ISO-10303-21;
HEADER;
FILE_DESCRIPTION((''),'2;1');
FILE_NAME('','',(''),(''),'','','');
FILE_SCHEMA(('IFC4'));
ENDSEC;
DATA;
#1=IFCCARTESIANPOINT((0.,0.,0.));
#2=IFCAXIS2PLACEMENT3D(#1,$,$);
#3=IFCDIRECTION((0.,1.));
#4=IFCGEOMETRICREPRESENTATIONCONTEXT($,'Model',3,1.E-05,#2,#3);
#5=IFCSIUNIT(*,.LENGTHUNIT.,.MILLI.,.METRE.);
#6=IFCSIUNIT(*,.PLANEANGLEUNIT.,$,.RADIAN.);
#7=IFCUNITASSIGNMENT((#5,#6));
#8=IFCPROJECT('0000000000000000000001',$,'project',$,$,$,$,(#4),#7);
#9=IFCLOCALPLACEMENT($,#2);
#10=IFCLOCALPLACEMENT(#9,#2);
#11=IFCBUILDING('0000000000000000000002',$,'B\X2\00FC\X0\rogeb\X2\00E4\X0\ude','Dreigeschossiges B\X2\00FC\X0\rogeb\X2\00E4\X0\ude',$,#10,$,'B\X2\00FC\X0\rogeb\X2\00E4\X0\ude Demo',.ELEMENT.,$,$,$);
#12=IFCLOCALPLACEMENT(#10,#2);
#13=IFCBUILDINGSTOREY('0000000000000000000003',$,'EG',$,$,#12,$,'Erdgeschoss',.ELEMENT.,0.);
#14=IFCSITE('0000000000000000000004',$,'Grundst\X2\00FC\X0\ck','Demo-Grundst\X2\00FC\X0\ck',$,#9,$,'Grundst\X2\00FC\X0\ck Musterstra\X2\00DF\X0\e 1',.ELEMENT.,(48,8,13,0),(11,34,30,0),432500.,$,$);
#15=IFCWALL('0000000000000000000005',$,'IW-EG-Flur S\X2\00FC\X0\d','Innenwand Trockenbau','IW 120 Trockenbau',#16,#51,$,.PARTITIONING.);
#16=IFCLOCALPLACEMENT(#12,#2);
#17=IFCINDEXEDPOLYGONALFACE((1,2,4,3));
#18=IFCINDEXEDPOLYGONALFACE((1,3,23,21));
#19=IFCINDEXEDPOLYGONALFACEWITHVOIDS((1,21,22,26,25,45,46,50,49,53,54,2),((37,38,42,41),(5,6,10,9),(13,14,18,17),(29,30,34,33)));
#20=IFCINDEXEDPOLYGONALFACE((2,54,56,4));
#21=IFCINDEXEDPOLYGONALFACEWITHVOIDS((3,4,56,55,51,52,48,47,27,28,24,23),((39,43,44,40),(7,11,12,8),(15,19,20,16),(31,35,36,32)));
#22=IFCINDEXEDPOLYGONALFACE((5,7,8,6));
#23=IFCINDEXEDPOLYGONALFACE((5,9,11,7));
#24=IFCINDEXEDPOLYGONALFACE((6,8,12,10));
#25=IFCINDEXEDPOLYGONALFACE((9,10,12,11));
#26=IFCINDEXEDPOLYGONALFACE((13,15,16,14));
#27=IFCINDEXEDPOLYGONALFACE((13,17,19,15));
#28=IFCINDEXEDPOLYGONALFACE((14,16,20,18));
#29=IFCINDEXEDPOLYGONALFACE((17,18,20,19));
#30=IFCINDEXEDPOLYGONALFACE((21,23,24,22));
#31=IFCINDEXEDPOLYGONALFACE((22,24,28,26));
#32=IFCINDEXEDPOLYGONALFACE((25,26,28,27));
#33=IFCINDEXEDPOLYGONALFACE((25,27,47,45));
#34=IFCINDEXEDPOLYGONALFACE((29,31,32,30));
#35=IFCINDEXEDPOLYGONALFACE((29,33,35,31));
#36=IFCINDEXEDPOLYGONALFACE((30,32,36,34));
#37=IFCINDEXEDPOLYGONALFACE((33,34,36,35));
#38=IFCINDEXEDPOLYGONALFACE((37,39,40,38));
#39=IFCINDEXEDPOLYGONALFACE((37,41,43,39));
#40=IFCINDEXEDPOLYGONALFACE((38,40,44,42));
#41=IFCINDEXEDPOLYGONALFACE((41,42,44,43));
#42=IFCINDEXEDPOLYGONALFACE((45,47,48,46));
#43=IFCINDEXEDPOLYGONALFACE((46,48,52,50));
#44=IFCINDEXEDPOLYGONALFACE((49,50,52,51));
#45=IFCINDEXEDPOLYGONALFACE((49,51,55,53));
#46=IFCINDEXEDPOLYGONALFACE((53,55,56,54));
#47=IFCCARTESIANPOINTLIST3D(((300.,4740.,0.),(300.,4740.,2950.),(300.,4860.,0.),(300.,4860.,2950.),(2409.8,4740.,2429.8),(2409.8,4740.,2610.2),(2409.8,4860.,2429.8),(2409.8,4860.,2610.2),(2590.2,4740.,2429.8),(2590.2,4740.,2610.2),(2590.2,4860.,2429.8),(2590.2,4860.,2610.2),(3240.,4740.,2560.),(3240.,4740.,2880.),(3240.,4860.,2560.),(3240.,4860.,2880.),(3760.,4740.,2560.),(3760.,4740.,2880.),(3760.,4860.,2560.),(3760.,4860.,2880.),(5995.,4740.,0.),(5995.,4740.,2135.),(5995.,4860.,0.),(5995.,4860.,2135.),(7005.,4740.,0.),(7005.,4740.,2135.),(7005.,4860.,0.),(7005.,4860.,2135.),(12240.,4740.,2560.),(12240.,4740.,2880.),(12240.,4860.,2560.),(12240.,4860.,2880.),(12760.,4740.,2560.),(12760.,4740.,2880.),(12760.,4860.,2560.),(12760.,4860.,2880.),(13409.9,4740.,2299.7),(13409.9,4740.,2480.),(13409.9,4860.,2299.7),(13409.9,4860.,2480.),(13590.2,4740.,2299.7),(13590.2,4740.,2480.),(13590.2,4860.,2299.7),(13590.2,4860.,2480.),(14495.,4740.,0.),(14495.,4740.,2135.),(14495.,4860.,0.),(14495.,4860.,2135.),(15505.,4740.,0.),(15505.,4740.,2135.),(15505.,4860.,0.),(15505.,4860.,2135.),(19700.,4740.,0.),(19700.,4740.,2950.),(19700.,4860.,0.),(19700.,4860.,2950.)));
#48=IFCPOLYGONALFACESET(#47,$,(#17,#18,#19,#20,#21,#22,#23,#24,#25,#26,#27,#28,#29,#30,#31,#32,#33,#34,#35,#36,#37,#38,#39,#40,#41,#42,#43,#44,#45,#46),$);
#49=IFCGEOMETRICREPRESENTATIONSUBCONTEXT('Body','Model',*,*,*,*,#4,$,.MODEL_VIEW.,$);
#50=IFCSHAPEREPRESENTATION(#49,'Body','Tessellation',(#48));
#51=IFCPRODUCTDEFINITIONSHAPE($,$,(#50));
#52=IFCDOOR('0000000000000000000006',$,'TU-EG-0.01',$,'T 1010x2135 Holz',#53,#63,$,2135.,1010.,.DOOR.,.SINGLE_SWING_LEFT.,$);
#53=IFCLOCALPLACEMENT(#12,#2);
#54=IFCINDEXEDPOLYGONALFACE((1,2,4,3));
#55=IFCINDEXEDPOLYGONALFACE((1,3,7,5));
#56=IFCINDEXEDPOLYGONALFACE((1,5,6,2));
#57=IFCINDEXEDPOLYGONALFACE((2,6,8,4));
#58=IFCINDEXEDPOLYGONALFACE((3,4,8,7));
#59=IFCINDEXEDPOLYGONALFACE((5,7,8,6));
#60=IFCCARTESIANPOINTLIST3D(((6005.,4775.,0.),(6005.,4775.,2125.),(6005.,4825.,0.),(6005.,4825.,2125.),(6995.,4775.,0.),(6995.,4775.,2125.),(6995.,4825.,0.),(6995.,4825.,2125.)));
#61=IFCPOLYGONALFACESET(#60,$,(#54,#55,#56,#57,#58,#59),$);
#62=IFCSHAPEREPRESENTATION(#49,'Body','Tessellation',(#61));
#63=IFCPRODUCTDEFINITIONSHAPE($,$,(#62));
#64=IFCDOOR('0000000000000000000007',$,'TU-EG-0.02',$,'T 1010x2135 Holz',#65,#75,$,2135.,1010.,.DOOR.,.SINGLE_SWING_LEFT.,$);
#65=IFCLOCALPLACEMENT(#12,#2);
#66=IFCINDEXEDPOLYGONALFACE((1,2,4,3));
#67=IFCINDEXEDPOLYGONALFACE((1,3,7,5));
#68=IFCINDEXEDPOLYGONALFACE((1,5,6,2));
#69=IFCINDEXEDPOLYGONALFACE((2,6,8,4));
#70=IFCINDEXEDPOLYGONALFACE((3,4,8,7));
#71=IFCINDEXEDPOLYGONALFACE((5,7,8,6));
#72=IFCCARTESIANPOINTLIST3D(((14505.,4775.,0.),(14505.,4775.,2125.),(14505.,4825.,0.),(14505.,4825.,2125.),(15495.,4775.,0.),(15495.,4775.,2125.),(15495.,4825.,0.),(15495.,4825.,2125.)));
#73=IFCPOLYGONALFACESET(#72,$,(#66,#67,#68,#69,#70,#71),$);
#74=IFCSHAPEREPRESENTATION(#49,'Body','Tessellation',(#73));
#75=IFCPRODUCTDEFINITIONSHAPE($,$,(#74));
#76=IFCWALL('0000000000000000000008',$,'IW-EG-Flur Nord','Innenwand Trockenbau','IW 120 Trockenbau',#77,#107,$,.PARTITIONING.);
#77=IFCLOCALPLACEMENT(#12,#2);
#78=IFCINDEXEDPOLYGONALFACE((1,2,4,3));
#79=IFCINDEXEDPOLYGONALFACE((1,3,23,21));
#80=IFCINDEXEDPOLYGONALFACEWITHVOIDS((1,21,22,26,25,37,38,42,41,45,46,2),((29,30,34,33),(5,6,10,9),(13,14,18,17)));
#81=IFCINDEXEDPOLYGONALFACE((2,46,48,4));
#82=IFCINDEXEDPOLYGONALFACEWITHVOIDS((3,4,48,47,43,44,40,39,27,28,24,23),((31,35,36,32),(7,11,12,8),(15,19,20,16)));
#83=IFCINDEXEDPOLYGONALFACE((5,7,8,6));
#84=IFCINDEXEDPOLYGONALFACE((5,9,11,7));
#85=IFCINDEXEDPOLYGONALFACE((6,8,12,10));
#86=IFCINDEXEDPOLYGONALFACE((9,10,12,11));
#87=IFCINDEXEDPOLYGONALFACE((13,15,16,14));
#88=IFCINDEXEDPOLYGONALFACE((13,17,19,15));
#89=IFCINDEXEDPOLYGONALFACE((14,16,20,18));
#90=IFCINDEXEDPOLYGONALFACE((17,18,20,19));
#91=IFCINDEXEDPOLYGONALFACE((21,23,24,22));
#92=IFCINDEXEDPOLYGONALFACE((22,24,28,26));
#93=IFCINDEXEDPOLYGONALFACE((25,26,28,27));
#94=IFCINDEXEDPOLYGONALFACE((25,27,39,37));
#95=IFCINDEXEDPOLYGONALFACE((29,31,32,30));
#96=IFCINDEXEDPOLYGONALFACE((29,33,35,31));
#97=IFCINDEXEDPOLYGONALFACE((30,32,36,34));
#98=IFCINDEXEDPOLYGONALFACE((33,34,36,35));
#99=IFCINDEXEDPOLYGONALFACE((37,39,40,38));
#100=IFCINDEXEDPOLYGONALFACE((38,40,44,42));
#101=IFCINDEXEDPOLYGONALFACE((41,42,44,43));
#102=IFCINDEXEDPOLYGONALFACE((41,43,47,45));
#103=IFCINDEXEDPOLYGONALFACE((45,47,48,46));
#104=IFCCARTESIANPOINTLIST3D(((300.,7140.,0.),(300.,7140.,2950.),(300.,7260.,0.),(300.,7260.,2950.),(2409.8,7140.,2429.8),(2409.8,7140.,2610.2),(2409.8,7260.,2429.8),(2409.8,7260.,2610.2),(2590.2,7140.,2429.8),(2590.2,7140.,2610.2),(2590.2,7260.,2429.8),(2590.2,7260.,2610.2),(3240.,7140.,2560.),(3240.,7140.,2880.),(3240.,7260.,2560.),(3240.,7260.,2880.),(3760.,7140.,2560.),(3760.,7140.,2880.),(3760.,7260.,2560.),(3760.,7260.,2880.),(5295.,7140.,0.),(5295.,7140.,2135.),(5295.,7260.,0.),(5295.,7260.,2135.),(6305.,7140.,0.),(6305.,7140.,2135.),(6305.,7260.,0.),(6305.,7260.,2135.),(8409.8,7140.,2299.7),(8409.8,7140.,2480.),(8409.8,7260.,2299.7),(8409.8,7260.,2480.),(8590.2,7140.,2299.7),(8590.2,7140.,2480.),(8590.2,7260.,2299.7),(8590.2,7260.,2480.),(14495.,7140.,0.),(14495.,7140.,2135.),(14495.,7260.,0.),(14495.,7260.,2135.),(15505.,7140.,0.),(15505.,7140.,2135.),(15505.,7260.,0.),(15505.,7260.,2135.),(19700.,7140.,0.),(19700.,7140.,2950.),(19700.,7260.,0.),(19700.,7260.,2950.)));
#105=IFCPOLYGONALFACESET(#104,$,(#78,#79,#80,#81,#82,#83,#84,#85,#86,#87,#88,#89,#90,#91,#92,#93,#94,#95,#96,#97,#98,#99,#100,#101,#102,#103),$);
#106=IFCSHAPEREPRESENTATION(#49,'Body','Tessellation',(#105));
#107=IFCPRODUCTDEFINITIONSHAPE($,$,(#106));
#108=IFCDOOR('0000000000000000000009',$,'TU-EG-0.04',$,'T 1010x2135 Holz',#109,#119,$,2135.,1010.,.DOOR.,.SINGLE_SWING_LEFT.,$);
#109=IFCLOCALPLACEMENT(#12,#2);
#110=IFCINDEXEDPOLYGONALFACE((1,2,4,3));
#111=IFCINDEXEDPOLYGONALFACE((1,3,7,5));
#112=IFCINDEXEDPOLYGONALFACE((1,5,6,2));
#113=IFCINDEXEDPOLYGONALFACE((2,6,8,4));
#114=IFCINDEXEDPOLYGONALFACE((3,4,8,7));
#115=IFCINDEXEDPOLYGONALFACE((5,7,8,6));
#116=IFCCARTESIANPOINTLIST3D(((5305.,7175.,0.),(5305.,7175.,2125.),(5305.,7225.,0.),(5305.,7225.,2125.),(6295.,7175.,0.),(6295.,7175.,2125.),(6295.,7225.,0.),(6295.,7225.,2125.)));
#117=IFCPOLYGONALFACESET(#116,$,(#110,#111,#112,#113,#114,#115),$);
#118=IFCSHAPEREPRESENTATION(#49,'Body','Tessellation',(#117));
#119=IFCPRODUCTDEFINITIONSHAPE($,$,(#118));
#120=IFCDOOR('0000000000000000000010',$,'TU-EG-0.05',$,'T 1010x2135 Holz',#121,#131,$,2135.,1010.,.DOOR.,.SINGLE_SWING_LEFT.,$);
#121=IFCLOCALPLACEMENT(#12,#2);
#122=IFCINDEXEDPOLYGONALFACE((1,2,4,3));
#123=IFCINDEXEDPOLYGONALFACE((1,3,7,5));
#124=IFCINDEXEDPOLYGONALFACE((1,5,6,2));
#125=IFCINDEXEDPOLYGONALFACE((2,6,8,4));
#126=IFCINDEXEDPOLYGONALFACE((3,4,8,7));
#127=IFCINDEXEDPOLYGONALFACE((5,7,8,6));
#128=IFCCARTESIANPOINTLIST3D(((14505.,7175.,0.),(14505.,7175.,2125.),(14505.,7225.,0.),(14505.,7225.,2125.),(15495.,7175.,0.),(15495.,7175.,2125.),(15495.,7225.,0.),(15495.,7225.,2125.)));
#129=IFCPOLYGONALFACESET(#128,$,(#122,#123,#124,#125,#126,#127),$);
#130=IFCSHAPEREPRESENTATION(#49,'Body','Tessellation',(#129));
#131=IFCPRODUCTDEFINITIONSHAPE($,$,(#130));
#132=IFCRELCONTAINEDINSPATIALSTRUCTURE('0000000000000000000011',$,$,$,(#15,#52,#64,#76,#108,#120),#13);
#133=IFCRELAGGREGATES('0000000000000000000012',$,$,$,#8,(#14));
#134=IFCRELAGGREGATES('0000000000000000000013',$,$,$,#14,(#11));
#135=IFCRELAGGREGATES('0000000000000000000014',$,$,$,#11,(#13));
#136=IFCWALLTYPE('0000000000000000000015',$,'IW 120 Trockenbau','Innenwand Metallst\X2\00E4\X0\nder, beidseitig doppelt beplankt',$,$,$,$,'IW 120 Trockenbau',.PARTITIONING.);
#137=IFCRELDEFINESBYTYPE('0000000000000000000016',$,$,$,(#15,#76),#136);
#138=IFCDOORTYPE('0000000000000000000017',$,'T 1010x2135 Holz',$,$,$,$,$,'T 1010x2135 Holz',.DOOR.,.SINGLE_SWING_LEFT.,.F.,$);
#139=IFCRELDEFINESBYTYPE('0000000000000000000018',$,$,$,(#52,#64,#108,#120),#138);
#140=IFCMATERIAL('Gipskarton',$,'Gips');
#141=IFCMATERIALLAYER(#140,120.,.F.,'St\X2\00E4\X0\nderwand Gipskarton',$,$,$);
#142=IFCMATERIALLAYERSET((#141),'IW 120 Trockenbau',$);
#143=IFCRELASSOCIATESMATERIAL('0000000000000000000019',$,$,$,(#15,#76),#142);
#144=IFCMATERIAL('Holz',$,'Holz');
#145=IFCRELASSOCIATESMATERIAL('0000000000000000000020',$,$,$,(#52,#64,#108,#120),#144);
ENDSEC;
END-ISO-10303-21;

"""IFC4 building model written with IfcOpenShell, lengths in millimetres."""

from ifc_helpers import new_model, si_unit, direction, frame, frame_2d, origin, origin_2d, place, context, subcontext, project, spatial, rectangle, extrude, material, layer, layer_set, layer_usage, type_object, element, fill, save


model = new_model("IFC4")

# Units and contexts
model_context = context("Model", 3, precision=1e-05, world=origin(), true_north=direction((0.0, 1.0)))
body_context = subcontext(model_context, "Body", "Model", "MODEL_VIEW")
ifc_project = project(units=[si_unit("LENGTHUNIT", "METRE", prefix="MILLI"), si_unit("PLANEANGLEUNIT", "RADIAN")], contexts=[model_context])

# Site, building, storey
site_placement = place(None, origin())
site = spatial("IfcSite", under=ifc_project, at=site_placement, Name="Grundstück", Description="Demo-Grundstück", LongName="Grundstück Musterstraße 1", CompositionType="ELEMENT", RefLatitude=(48, 8, 13, 0), RefLongitude=(11, 34, 30, 0), RefElevation=432500.0)
building_placement = place(site_placement, origin())
building = spatial("IfcBuilding", under=site, at=building_placement, Name="Bürogebäude", Description="Dreigeschossiges Bürogebäude", LongName="Bürogebäude Demo", CompositionType="ELEMENT")
storey_placement = place(building_placement, origin())
storey = spatial("IfcBuildingStorey", under=building, at=storey_placement, Name="EG", LongName="Erdgeschoss", CompositionType="ELEMENT", Elevation=0.0)

# Walls, openings, doors
ifc_material_1 = material(Name="Gipskarton", Category="Gips")
ifc_layer_1 = layer(ifc_material_1, 120.0, ventilated=False, Name="Ständerwand Gipskarton")
ifc_layer_set_1 = layer_set([ifc_layer_1], Name="IW 120 Trockenbau")
ifc_layer_usage_1 = layer_usage(ifc_layer_set_1, "AXIS2", "POSITIVE", -60.0)
wall_type_1 = type_object("IfcWallType", Name="IW 120 Trockenbau", Description="Innenwand Metallständer, beidseitig doppelt beplankt", ElementType="IW 120 Trockenbau", PredefinedType="PARTITIONING")
wall_1_placement = place(storey_placement, frame((300.0, 4800.0, 0.0)))
wall_1 = element("IfcWall", 1, at=wall_1_placement, inside=storey, type_object=wall_type_1, material=ifc_layer_usage_1, Name="IW-EG-Flur Süd", Description="Innenwand Trockenbau", ObjectType="IW 120 Trockenbau", PredefinedType="PARTITIONING", context=body_context, shape_type="SweptSolid", body=[
    extrude(rectangle(XDim=19400.0, YDim=120.0, at=frame_2d((9700.0, 0.0))), origin(), (0.0, 0.0, 1.0), 2950.0),
])
opening_1_placement = place(wall_1_placement, frame((6200.0, 0.0, 0.0)))
opening_1 = element("IfcOpeningElement", 2, at=opening_1_placement, cuts=wall_1, PredefinedType="OPENING", context=body_context, shape_type="SweptSolid", body=[
    extrude(rectangle(XDim=1010.0, YDim=160.0, at=origin_2d()), frame((0.0, 0.0, -20.0)), (0.0, 0.0, 1.0), 2155.0),
])
opening_2_placement = place(wall_1_placement, frame((14700.0, 0.0, 0.0)))
opening_2 = element("IfcOpeningElement", 3, at=opening_2_placement, cuts=wall_1, PredefinedType="OPENING", context=body_context, shape_type="SweptSolid", body=[
    extrude(rectangle(XDim=1010.0, YDim=160.0, at=origin_2d()), frame((0.0, 0.0, -20.0)), (0.0, 0.0, 1.0), 2155.0),
])
opening_3_placement = place(wall_1_placement, frame((3200.0, 0.0, 2560.0)))
element("IfcOpeningElement", 4, at=opening_3_placement, cuts=wall_1, PredefinedType="OPENING", context=body_context, shape_type="SweptSolid", body=[
    extrude(rectangle(XDim=520.0, YDim=160.0, at=origin_2d()), origin(), (0.0, 0.0, 1.0), 320.0),
])
opening_4_placement = place(wall_1_placement, frame((2200.0, 0.0, 2429.8)))
element("IfcOpeningElement", 5, at=opening_4_placement, cuts=wall_1, PredefinedType="OPENING", context=body_context, shape_type="SweptSolid", body=[
    extrude(rectangle(XDim=180.3, YDim=160.0, at=origin_2d()), origin(), (0.0, 0.0, 1.0), 180.3),
])
opening_5_placement = place(wall_1_placement, frame((12200.0, 0.0, 2560.0)))
element("IfcOpeningElement", 6, at=opening_5_placement, cuts=wall_1, PredefinedType="OPENING", context=body_context, shape_type="SweptSolid", body=[
    extrude(rectangle(XDim=520.0, YDim=160.0, at=origin_2d()), origin(), (0.0, 0.0, 1.0), 320.0),
])
opening_6_placement = place(wall_1_placement, frame((13200.0, 0.0, 2299.7)))
element("IfcOpeningElement", 7, at=opening_6_placement, cuts=wall_1, PredefinedType="OPENING", context=body_context, shape_type="SweptSolid", body=[
    extrude(rectangle(XDim=180.3, YDim=160.0, at=origin_2d()), origin(), (0.0, 0.0, 1.0), 180.3),
])
ifc_material_2 = material(Name="Holz", Category="Holz")
door_type = type_object("IfcDoorType", Name="T 1010x2135 Holz", ElementType="T 1010x2135 Holz", OperationType="SINGLE_SWING_LEFT", ParameterTakesPrecedence=False, PredefinedType="DOOR")
door_1_placement = place(opening_1_placement, origin())
door_1 = element("IfcDoor", 8, at=door_1_placement, inside=storey, type_object=door_type, material=ifc_material_2, Name="TU-EG-0.01", ObjectType="T 1010x2135 Holz", OperationType="SINGLE_SWING_LEFT", OverallHeight=2135.0, OverallWidth=1010.0, PredefinedType="DOOR", context=body_context, shape_type="SweptSolid", body=[
    extrude(rectangle(XDim=990.0, YDim=50.0, at=origin_2d()), origin(), (0.0, 0.0, 1.0), 2125.0),
])
fill(opening_1, door_1)
door_2_placement = place(opening_2_placement, origin())
door_2 = element("IfcDoor", 9, at=door_2_placement, inside=storey, type_object=door_type, material=ifc_material_2, Name="TU-EG-0.02", ObjectType="T 1010x2135 Holz", OperationType="SINGLE_SWING_LEFT", OverallHeight=2135.0, OverallWidth=1010.0, PredefinedType="DOOR", context=body_context, shape_type="SweptSolid", body=[
    extrude(rectangle(XDim=990.0, YDim=50.0, at=origin_2d()), origin(), (0.0, 0.0, 1.0), 2125.0),
])
fill(opening_2, door_2)
wall_2_placement = place(storey_placement, frame((300.0, 7200.0, 0.0)))
wall_2 = element("IfcWall", 10, at=wall_2_placement, inside=storey, type_object=wall_type_1, material=ifc_layer_usage_1, Name="IW-EG-Flur Nord", Description="Innenwand Trockenbau", ObjectType="IW 120 Trockenbau", PredefinedType="PARTITIONING", context=body_context, shape_type="SweptSolid", body=[
    extrude(rectangle(XDim=19400.0, YDim=120.0, at=frame_2d((9700.0, 0.0))), origin(), (0.0, 0.0, 1.0), 2950.0),
])
opening_7_placement = place(wall_2_placement, frame((5500.0, 0.0, 0.0)))
opening_7 = element("IfcOpeningElement", 11, at=opening_7_placement, cuts=wall_2, PredefinedType="OPENING", context=body_context, shape_type="SweptSolid", body=[
    extrude(rectangle(XDim=1010.0, YDim=160.0, at=origin_2d()), frame((0.0, 0.0, -20.0)), (0.0, 0.0, 1.0), 2155.0),
])
opening_8_placement = place(wall_2_placement, frame((14700.0, 0.0, 0.0)))
opening_8 = element("IfcOpeningElement", 12, at=opening_8_placement, cuts=wall_2, PredefinedType="OPENING", context=body_context, shape_type="SweptSolid", body=[
    extrude(rectangle(XDim=1010.0, YDim=160.0, at=origin_2d()), frame((0.0, 0.0, -20.0)), (0.0, 0.0, 1.0), 2155.0),
])
opening_9_placement = place(wall_2_placement, frame((3200.0, 0.0, 2560.0)))
element("IfcOpeningElement", 13, at=opening_9_placement, cuts=wall_2, PredefinedType="OPENING", context=body_context, shape_type="SweptSolid", body=[
    extrude(rectangle(XDim=520.0, YDim=160.0, at=origin_2d()), origin(), (0.0, 0.0, 1.0), 320.0),
])
opening_10_placement = place(wall_2_placement, frame((2200.0, 0.0, 2429.8)))
element("IfcOpeningElement", 14, at=opening_10_placement, cuts=wall_2, PredefinedType="OPENING", context=body_context, shape_type="SweptSolid", body=[
    extrude(rectangle(XDim=180.3, YDim=160.0, at=origin_2d()), origin(), (0.0, 0.0, 1.0), 180.3),
])
opening_11_placement = place(wall_2_placement, frame((8200.0, 0.0, 2299.7)))
element("IfcOpeningElement", 15, at=opening_11_placement, cuts=wall_2, PredefinedType="OPENING", context=body_context, shape_type="SweptSolid", body=[
    extrude(rectangle(XDim=180.3, YDim=160.0, at=origin_2d()), origin(), (0.0, 0.0, 1.0), 180.3),
])
door_3_placement = place(opening_7_placement, origin())
door_3 = element("IfcDoor", 16, at=door_3_placement, inside=storey, type_object=door_type, material=ifc_material_2, Name="TU-EG-0.04", ObjectType="T 1010x2135 Holz", OperationType="SINGLE_SWING_LEFT", OverallHeight=2135.0, OverallWidth=1010.0, PredefinedType="DOOR", context=body_context, shape_type="SweptSolid", body=[
    extrude(rectangle(XDim=990.0, YDim=50.0, at=origin_2d()), origin(), (0.0, 0.0, 1.0), 2125.0),
])
fill(opening_7, door_3)
door_4_placement = place(opening_8_placement, origin())
door_4 = element("IfcDoor", 17, at=door_4_placement, inside=storey, type_object=door_type, material=ifc_material_2, Name="TU-EG-0.05", ObjectType="T 1010x2135 Holz", OperationType="SINGLE_SWING_LEFT", OverallHeight=2135.0, OverallWidth=1010.0, PredefinedType="DOOR", context=body_context, shape_type="SweptSolid", body=[
    extrude(rectangle(XDim=990.0, YDim=50.0, at=origin_2d()), origin(), (0.0, 0.0, 1.0), 2125.0),
])
fill(opening_8, door_4)

save(model, "model.ifc")
